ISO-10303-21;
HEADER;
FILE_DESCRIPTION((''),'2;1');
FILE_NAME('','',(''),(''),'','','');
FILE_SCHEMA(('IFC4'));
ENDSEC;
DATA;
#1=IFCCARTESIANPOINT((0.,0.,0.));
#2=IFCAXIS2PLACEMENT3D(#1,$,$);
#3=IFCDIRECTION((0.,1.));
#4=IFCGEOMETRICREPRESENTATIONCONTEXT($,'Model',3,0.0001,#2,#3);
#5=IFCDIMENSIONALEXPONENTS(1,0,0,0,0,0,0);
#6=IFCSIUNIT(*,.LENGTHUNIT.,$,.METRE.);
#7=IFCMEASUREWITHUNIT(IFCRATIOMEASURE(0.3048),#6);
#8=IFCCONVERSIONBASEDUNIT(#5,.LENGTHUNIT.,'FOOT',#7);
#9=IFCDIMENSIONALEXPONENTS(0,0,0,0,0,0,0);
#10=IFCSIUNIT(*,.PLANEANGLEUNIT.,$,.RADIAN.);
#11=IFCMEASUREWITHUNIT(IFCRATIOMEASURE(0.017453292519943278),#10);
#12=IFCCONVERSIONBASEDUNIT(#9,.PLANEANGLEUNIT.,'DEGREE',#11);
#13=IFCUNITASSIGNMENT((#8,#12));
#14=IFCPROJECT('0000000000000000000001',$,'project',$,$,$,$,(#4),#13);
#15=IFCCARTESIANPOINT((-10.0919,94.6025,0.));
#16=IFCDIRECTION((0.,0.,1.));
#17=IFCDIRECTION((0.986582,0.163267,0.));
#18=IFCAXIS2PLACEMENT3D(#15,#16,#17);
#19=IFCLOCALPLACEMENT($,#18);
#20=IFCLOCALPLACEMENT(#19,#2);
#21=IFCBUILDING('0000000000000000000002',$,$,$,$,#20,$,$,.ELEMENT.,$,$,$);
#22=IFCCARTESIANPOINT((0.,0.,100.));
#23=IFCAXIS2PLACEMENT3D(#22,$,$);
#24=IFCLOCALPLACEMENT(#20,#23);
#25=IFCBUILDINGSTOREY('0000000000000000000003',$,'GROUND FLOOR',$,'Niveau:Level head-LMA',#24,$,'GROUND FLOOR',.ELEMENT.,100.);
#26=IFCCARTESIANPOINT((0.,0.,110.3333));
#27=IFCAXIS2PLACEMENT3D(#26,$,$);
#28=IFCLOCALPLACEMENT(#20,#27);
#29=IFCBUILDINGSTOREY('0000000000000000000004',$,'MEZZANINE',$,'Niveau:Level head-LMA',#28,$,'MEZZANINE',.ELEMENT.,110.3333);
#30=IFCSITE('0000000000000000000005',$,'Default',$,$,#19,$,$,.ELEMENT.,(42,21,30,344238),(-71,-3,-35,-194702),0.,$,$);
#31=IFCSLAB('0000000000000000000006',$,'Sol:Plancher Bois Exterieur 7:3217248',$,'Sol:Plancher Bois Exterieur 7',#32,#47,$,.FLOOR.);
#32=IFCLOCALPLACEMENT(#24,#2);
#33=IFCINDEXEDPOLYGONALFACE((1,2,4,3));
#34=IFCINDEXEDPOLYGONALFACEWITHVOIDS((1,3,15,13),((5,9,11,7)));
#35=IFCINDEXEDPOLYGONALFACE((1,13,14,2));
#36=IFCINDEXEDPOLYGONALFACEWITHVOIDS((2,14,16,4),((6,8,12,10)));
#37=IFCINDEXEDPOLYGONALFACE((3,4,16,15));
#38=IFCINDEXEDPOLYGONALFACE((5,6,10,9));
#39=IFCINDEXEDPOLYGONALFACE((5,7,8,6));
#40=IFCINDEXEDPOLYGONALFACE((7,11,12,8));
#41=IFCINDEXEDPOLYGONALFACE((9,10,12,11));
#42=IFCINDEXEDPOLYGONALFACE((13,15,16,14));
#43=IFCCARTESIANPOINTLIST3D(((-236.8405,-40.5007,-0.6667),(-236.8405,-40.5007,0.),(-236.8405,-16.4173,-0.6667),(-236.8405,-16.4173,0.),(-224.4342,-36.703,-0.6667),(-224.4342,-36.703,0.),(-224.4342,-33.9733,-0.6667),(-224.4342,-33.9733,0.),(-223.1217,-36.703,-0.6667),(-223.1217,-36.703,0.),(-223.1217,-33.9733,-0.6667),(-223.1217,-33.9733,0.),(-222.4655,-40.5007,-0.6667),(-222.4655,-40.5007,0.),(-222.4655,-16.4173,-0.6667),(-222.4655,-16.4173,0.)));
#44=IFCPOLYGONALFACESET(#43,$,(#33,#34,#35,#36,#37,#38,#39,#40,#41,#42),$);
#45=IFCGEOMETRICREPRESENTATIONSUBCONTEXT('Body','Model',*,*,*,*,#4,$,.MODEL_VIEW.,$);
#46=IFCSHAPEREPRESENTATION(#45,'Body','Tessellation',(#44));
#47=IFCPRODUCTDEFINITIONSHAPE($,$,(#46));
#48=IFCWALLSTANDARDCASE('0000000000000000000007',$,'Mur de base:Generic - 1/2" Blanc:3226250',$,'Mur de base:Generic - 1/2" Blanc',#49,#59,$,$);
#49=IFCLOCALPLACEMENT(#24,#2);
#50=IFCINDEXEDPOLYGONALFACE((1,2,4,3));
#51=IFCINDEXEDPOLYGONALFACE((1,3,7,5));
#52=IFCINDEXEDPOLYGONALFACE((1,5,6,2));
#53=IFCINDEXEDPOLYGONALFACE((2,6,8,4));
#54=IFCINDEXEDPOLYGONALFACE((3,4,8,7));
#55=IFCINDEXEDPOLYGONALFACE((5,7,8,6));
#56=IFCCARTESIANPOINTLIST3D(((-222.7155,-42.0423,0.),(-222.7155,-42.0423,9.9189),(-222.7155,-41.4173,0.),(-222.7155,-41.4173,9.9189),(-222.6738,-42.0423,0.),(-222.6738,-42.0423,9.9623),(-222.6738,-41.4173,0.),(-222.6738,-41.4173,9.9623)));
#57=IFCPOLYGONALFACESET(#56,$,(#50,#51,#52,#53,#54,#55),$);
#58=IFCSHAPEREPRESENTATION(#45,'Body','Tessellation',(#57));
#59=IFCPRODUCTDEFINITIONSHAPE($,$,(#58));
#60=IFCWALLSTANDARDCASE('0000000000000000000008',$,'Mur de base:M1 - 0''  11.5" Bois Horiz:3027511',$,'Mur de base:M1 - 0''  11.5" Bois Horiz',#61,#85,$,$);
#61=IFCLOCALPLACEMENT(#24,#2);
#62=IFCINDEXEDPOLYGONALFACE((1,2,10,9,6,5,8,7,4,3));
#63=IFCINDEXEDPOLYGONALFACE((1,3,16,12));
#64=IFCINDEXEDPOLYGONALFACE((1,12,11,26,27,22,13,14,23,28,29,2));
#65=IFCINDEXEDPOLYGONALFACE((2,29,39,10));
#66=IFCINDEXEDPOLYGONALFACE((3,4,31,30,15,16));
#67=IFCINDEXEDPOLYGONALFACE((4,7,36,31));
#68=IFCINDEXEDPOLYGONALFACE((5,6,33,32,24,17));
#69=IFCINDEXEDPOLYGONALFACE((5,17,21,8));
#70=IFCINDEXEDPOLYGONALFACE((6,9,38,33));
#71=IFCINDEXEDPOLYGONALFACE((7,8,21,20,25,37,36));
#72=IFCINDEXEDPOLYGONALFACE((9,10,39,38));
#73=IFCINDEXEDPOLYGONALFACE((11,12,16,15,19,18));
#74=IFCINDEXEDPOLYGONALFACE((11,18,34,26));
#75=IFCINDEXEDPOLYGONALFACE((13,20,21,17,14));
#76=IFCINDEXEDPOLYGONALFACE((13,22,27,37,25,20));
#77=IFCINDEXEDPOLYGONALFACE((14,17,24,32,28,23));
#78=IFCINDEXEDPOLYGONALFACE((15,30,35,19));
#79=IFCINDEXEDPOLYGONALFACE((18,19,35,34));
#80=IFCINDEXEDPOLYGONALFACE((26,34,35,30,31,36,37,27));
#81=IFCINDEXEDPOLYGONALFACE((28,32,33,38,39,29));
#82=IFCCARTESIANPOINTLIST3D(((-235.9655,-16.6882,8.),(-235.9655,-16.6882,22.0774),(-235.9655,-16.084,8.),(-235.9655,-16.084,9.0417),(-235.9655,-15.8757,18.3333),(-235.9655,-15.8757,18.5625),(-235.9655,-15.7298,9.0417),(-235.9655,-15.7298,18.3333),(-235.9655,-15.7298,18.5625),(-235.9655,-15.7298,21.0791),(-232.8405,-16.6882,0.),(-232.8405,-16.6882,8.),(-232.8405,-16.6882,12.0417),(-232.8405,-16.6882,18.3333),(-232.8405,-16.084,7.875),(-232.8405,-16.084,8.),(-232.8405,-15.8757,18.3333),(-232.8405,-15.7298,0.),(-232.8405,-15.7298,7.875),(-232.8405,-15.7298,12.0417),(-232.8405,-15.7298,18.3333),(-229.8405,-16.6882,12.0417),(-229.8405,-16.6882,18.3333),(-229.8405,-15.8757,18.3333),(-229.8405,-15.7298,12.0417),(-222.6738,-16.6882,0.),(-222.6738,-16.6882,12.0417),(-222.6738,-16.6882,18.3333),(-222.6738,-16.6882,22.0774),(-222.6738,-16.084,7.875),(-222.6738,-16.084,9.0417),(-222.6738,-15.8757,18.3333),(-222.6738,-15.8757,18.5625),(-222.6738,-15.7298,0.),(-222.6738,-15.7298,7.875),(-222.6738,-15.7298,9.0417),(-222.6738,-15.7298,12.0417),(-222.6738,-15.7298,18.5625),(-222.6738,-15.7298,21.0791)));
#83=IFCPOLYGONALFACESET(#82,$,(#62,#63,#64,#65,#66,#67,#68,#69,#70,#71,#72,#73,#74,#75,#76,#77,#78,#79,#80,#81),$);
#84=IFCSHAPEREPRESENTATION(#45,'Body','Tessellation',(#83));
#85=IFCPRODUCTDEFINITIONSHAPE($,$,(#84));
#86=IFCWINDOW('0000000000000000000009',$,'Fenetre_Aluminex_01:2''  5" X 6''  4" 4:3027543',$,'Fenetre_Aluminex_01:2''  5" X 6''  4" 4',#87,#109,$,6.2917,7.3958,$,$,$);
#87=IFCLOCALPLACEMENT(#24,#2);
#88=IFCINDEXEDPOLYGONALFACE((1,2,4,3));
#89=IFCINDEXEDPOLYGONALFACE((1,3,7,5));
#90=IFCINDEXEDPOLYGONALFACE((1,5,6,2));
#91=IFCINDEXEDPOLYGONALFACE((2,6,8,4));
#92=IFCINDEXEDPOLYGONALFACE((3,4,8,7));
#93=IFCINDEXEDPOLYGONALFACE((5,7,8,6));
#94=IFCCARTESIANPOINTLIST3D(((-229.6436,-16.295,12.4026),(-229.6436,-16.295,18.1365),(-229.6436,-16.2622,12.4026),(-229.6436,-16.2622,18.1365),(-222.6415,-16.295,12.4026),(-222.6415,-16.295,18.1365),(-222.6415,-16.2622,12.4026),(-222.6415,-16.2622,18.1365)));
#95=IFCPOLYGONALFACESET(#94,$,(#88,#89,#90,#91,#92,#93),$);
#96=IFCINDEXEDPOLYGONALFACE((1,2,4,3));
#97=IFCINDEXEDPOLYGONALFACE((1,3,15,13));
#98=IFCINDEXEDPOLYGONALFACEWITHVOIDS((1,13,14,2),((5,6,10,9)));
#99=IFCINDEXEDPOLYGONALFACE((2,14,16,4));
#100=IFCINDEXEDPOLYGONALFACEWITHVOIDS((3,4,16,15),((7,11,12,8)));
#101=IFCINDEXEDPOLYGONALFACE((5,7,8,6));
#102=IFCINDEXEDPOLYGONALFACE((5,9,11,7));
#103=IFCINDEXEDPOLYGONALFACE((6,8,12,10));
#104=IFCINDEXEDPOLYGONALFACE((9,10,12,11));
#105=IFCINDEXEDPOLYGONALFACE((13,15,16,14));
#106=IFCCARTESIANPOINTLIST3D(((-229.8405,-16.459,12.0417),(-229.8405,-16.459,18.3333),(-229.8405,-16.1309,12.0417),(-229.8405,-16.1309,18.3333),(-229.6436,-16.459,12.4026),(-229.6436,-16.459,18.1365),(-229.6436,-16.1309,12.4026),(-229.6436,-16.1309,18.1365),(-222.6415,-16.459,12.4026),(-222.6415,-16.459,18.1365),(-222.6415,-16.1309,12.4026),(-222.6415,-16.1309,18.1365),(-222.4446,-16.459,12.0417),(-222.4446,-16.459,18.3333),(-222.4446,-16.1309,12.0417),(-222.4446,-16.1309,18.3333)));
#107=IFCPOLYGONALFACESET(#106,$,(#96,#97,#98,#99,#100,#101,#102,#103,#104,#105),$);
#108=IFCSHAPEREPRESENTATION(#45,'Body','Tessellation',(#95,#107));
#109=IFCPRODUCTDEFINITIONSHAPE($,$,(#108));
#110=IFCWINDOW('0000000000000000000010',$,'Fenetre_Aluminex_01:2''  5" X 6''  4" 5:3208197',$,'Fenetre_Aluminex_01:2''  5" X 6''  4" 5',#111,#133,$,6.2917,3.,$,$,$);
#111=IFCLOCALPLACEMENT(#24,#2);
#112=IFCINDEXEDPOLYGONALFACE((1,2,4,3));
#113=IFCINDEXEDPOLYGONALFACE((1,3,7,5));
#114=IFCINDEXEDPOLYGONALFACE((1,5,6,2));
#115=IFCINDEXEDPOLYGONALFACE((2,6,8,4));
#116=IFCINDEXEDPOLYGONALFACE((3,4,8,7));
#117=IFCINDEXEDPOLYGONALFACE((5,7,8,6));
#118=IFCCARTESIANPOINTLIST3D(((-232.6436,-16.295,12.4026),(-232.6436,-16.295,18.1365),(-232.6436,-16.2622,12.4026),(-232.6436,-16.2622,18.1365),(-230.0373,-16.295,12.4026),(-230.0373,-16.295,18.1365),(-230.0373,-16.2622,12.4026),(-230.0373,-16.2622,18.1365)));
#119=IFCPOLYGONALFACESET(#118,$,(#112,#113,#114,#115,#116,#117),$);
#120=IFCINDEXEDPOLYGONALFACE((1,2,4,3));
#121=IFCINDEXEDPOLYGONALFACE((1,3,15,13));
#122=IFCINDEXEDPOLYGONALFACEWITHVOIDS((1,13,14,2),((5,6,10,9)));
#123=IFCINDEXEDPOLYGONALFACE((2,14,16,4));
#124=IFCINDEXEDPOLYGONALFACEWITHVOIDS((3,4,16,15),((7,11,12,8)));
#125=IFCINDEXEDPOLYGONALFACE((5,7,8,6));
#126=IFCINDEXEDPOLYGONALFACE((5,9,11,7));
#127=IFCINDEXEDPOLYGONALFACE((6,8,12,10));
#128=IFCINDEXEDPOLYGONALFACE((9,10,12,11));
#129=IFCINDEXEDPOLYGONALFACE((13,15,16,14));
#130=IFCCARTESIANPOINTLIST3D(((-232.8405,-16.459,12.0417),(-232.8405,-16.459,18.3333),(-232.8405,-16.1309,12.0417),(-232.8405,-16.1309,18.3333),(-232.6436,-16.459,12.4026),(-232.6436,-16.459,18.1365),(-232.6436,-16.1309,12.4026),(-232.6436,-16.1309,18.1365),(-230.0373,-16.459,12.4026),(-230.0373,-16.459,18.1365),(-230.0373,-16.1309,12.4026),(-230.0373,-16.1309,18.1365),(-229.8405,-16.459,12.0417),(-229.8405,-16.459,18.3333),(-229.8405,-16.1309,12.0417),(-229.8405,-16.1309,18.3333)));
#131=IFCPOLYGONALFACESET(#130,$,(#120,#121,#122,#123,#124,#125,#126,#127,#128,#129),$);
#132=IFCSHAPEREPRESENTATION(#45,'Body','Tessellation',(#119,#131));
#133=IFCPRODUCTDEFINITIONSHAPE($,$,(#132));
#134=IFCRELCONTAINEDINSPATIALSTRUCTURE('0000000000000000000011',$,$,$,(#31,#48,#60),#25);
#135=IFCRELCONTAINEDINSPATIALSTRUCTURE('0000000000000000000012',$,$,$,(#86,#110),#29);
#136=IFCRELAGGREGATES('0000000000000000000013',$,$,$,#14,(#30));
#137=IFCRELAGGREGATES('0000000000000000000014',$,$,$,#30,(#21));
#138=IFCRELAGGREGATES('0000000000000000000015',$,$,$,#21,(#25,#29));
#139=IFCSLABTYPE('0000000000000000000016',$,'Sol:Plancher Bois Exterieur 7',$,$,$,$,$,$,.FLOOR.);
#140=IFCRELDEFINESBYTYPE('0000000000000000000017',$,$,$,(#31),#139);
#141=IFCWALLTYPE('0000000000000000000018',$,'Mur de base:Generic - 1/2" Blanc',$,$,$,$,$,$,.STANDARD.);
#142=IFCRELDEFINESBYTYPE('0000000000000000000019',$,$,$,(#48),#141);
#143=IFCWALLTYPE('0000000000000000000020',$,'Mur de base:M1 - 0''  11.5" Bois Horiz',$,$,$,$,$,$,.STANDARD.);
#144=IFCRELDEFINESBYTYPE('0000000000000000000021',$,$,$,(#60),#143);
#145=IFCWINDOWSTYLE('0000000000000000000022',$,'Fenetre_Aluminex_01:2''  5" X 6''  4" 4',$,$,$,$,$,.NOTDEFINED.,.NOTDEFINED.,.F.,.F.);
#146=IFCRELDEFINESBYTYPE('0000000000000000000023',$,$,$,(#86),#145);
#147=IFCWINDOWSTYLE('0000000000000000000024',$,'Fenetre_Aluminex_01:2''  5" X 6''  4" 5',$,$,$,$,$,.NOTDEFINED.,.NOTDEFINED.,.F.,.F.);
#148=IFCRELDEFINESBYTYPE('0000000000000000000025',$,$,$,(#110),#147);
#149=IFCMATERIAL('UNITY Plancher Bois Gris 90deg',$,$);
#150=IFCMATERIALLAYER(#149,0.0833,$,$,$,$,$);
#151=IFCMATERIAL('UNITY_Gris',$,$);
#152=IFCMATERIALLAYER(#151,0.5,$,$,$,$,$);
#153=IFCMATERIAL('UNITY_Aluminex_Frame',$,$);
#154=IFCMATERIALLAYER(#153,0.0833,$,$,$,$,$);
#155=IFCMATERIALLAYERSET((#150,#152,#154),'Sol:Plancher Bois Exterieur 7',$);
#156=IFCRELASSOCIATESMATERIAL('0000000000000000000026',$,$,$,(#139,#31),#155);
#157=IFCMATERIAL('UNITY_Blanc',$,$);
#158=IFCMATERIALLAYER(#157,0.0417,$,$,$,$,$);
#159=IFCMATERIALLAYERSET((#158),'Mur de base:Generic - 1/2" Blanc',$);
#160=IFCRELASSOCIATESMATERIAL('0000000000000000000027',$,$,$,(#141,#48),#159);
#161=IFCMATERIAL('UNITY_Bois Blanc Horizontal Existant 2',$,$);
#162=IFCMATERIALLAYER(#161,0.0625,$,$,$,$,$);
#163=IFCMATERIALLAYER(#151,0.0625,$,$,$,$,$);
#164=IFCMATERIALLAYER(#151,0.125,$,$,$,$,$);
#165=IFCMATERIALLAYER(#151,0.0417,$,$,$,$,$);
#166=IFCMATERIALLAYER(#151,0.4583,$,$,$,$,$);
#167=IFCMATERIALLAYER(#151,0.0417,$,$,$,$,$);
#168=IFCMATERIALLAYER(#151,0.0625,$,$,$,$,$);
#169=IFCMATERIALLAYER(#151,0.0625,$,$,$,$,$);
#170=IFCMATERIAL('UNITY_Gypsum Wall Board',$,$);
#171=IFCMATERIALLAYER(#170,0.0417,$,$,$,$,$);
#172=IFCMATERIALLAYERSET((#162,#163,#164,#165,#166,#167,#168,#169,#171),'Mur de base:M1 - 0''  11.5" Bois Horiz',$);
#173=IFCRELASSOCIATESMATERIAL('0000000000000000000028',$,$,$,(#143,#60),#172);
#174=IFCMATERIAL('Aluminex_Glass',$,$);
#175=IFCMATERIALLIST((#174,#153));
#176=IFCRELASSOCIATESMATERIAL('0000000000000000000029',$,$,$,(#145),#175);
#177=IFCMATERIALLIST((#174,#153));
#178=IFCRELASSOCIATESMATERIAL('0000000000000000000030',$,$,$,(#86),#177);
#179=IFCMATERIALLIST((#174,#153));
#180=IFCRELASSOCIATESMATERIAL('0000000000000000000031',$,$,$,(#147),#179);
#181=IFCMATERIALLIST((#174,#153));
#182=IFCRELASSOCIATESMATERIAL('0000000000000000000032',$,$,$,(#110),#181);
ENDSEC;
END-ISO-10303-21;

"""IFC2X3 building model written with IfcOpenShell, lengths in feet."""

from ifc_helpers import new_model, entity, si_unit, converted_unit, direction, frame, frame_2d, origin, origin_2d_with_axis, place, context, subcontext, project, spatial, polyline, rectangle, outline, extrude, clip, bounded_halfspace, source, transform, mapped, material, material_list, layer, layer_set, layer_usage, type_object, type_shapes, element, fill, save


model = new_model("IFC2X3")

# Units and contexts
model_context = context("Model", 3, precision=0.0001, world=origin(), true_north=direction((0.0, 1.0)))
body_context = subcontext(model_context, "Body", "Model", "MODEL_VIEW")
ifc_project = project(units=[converted_unit("LENGTHUNIT", "FOOT", entity("IfcRatioMeasure", 0.3048), si_unit("LENGTHUNIT", "METRE"), dimensions=[1, 0, 0, 0, 0, 0, 0]), converted_unit("PLANEANGLEUNIT", "DEGREE", entity("IfcRatioMeasure", 0.017453292519943278), si_unit("PLANEANGLEUNIT", "RADIAN"), dimensions=[0, 0, 0, 0, 0, 0, 0])], contexts=[model_context])

# Site, building, storey
site_placement = place(None, frame((-10.0919, 94.6025, 0.0), z_axis=(0.0, 0.0, 1.0), x_axis=(0.986582, 0.163267, 0.0)))
site = spatial("IfcSite", under=ifc_project, at=site_placement, Name="Default", CompositionType="ELEMENT", RefLatitude=(42, 21, 30, 344238), RefLongitude=(-71, -3, -35, -194702), RefElevation=0.0)
building_placement = place(site_placement, origin())
building = spatial("IfcBuilding", under=site, at=building_placement, CompositionType="ELEMENT")
storey_1_placement = place(building_placement, frame((0.0, 0.0, 100.0)))
storey_1 = spatial("IfcBuildingStorey", under=building, at=storey_1_placement, Name="GROUND FLOOR", ObjectType="Niveau:Level head-LMA", LongName="GROUND FLOOR", CompositionType="ELEMENT", Elevation=100.0)

# Shared definitions
ifc_material_1 = material(Name="UNITY_Aluminex_Frame")

# Slab, opening
ifc_material_2 = material(Name="UNITY Plancher Bois Gris 90deg")
ifc_layer_1 = layer(ifc_material_2, 0.0833)
ifc_material_3 = material(Name="UNITY_Gris")
ifc_layer_2 = layer(ifc_material_3, 0.5)
ifc_layer_3 = layer(ifc_material_1, 0.0833)
ifc_layer_set_1 = layer_set([ifc_layer_1, ifc_layer_2, ifc_layer_3], Name="Sol:Plancher Bois Exterieur 7")
ifc_layer_usage_1 = layer_usage(ifc_layer_set_1, "AXIS3", "POSITIVE", 0.0)
slab_type = type_object("IfcSlabType", Name="Sol:Plancher Bois Exterieur 7", PredefinedType="FLOOR", material=ifc_layer_set_1)
slab_placement = place(storey_1_placement, frame((-236.8405, -40.5007, -0.6667)))
slab = element("IfcSlab", 1, at=slab_placement, inside=storey_1, type_object=slab_type, material=ifc_layer_usage_1, Name="Sol:Plancher Bois Exterieur 7:3217248", ObjectType="Sol:Plancher Bois Exterieur 7", PredefinedType="FLOOR", context=body_context, shape_type="SweptSolid", body=[
    extrude(rectangle(XDim=24.0833, YDim=14.375, at=frame_2d((0.0, 0.0), x_axis=(0.0, 1.0))), frame((7.1875, 12.0417, 0.6667), z_axis=(0.0, 0.0, -1.0), x_axis=(-1.0, 0.0, 0.0)), (0.0, 0.0, 1.0), 0.6667),
])
opening_1_placement = place(slab_placement, frame((13.0625, 5.1625, 0.6667)))
element("IfcOpeningElement", 2, at=opening_1_placement, cuts=slab, ObjectType="Opening", context=body_context, shape_type="SweptSolid", body=[
    extrude(rectangle(XDim=2.7297, YDim=1.3125, at=origin_2d_with_axis()), frame((0.0, 0.0, 0.0), z_axis=(0.0, 0.0, -1.0), x_axis=(0.0, 1.0, 0.0)), (0.0, 0.0, 1.0), 0.6667),
])

# Wall
ifc_material_4 = material(Name="UNITY_Blanc")
ifc_layer_4 = layer(ifc_material_4, 0.0417)
ifc_layer_set_2 = layer_set([ifc_layer_4], Name="Mur de base:Generic - 1/2\" Blanc")
ifc_layer_usage_2 = layer_usage(ifc_layer_set_2, "AXIS2", "POSITIVE", -0.0208)
wall_type_1 = type_object("IfcWallType", Name="Mur de base:Generic - 1/2\" Blanc", PredefinedType="STANDARD", material=ifc_layer_set_2)
wall_1_placement = place(storey_1_placement, frame((-222.6947, -41.4173, 0.0), z_axis=(0.0, 0.0, 1.0), x_axis=(0.0, -1.0, 0.0)))
element("IfcWallStandardCase", 3, at=wall_1_placement, inside=storey_1, type_object=wall_type_1, material=ifc_layer_usage_2, Name="Mur de base:Generic - 1/2\" Blanc:3226250", ObjectType="Mur de base:Generic - 1/2\" Blanc", context=body_context, shape_type="Clipping", body=[
    clip(extrude(rectangle(XDim=0.625, YDim=0.0417, at=frame_2d((0.3125, 0.0), x_axis=(-1.0, 0.0))), origin(), (0.0, 0.0, 1.0), 9.9623), bounded_halfspace(frame((0.0, -0.0208, 9.9189), z_axis=(0.0, -0.721387, 0.692532), x_axis=(1.0, 0.0, 0.0)), False, frame((0.0, -0.0208, 9.9189)), polyline([(0.0, 0.0), (0.625, 0.0), (0.625, 0.0417), (0.0, 0.0417), (0.0, 0.0)]))),
])

# Wall, openings
ifc_material_5 = material(Name="UNITY_Bois Blanc Horizontal Existant 2")
ifc_layer_5 = layer(ifc_material_5, 0.0625)
ifc_layer_6 = layer(ifc_material_3, 0.0625)
ifc_layer_7 = layer(ifc_material_3, 0.125)
ifc_layer_8 = layer(ifc_material_3, 0.0417)
ifc_layer_9 = layer(ifc_material_3, 0.4583)
ifc_layer_10 = layer(ifc_material_3, 0.0417)
ifc_layer_11 = layer(ifc_material_3, 0.0625)
ifc_layer_12 = layer(ifc_material_3, 0.0625)
ifc_material_6 = material(Name="UNITY_Gypsum Wall Board")
ifc_layer_13 = layer(ifc_material_6, 0.0417)
ifc_layer_set_3 = layer_set([ifc_layer_5, ifc_layer_6, ifc_layer_7, ifc_layer_8, ifc_layer_9, ifc_layer_10, ifc_layer_11, ifc_layer_12, ifc_layer_13], Name="Mur de base:M1 - 0'  11.5\" Bois Horiz")
ifc_layer_usage_3 = layer_usage(ifc_layer_set_3, "AXIS2", "NEGATIVE", 0.4792)
wall_type_2 = type_object("IfcWallType", Name="Mur de base:M1 - 0'  11.5\" Bois Horiz", PredefinedType="STANDARD", material=ifc_layer_set_3)
wall_2_placement = place(storey_1_placement, frame((-222.6738, -16.209, 0.0), z_axis=(0.0, 0.0, 1.0), x_axis=(-1.0, 0.0, 0.0)))
wall_2 = element("IfcWallStandardCase", 4, at=wall_2_placement, inside=storey_1, type_object=wall_type_2, material=ifc_layer_usage_3, Name="Mur de base:M1 - 0'  11.5\" Bois Horiz:3027511", ObjectType="Mur de base:M1 - 0'  11.5\" Bois Horiz", context=body_context, shape_type="Clipping", body=[
    clip(clip(clip(extrude(rectangle(XDim=13.2917, YDim=0.9583, at=frame_2d((6.6458, 0.0), x_axis=(-1.0, 0.0))), origin(), (0.0, 0.0, 1.0), 22.0774), bounded_halfspace(frame((0.0, -0.4792, 21.0791), z_axis=(0.0, -0.721387, 0.692532), x_axis=(1.0, 0.0, 0.0)), False, frame((0.0, -0.4792, 21.0791)), polyline([(0.0, 0.0), (13.2917, 0.0), (13.2917, 0.2708), (13.2917, 0.9583), (0.0, 0.9583), (0.0, 0.0)]))), bounded_halfspace(frame((13.2917, -0.125, 9.0417), z_axis=(0.0, 1.0, 0.0), x_axis=(0.0, 0.0, 1.0)), True, frame((13.2917, -0.125, 9.0417), z_axis=(0.0, 1.0, 0.0), x_axis=(0.0, 0.0, 1.0)), polyline([(0.0, 0.0), (-1.0417, 0.0), (-1.0417, -3.125), (-1.1667, -3.125), (-1.1667, -13.2917), (0.0, -13.2917), (0.0, 0.0)]))), bounded_halfspace(frame((10.1666, -0.3333, 18.3333), z_axis=(0.0, 1.0, 0.0), x_axis=(0.0, 0.0, -1.0)), True, frame((10.1666, -0.3333, 18.3333), z_axis=(0.0, 1.0, 0.0), x_axis=(0.0, 0.0, -1.0)), polyline([(0.0, 0.0), (0.0, 10.1666), (-0.2292, 10.1666), (-0.2292, -3.125), (0.0, -3.125), (0.0, 0.0)]))),
])
opening_2_placement = place(wall_2_placement, origin())
element("IfcOpeningElement", 5, at=opening_2_placement, cuts=wall_2, ObjectType="Opening", context=body_context, shape_type="SweptSolid", body=[
    extrude(rectangle(XDim=6.2917, YDim=0.6875, at=frame_2d((0.0, 0.0), x_axis=(0.0, 1.0))), frame((-0.3438, 0.25, 15.1875), z_axis=(0.0, 1.0, 0.0), x_axis=(1.0, 0.0, 0.0)), (0.0, 0.0, 1.0), 3.0),
])
opening_3_placement = place(wall_2_placement, origin())
element("IfcOpeningElement", 6, at=opening_3_placement, cuts=wall_2, ObjectType="Opening", context=body_context, shape_type="SweptSolid", body=[
    extrude(rectangle(XDim=8.0, YDim=0.6667, at=frame_2d((0.0, 0.0), x_axis=(0.0, 1.0))), frame((13.6666, -3.0, 4.0), z_axis=(0.0, 1.0, 0.0), x_axis=(-1.0, 0.0, 0.0)), (0.0, 0.0, 1.0), 2.875),
])
opening_4_placement = place(wall_2_placement, frame((-222.6738, -16.209, 0.0), z_axis=(0.0, 0.0, 1.0), x_axis=(-1.0, 0.0, 0.0)))
element("IfcOpeningElement", 7, at=opening_4_placement, cuts=wall_2, ObjectType="Opening", context=body_context, shape_type="SweptSolid", body=[
    extrude(rectangle(XDim=8.0, YDim=3.1667, at=frame_2d((0.0, 0.0), x_axis=(0.0, 1.0))), frame((-234.4238, -11.6882, 4.0), z_axis=(0.0, -1.0, 0.0), x_axis=(1.0, 0.0, 0.0)), (0.0, 0.0, 1.0), 10.0),
])
opening_5_placement = place(wall_2_placement, frame((-0.2292, -0.4792, 12.0417)))
opening_5 = element("IfcOpeningElement", 8, at=opening_5_placement, cuts=wall_2, ObjectType="Opening", context=body_context, shape_type="SweptSolid", body=[
    extrude(rectangle(XDim=6.2917, YDim=7.3958, at=frame_2d((3.1458, 3.6979), x_axis=(1.0, 0.0))), frame((0.0, 0.0, 0.0), z_axis=(0.0, 1.0, 0.0), x_axis=(0.0, 0.0, 1.0)), (0.0, 0.0, 1.0), 0.9583),
])
opening_6_placement = place(wall_2_placement, frame((7.1666, -0.4792, 12.0417)))
opening_6 = element("IfcOpeningElement", 9, at=opening_6_placement, cuts=wall_2, ObjectType="Opening", context=body_context, shape_type="SweptSolid", body=[
    extrude(rectangle(XDim=6.2917, YDim=3.0, at=frame_2d((3.1458, 1.5), x_axis=(1.0, 0.0))), frame((0.0, 0.0, 0.0), z_axis=(0.0, 1.0, 0.0), x_axis=(0.0, 0.0, 1.0)), (0.0, 0.0, 1.0), 0.9583),
])

# Shared definitions
storey_2_placement = place(building_placement, frame((0.0, 0.0, 110.3333)))
storey_2 = spatial("IfcBuildingStorey", under=building, at=storey_2_placement, Name="MEZZANINE", ObjectType="Niveau:Level head-LMA", LongName="MEZZANINE", CompositionType="ELEMENT", Elevation=110.3333)

# Windows
ifc_material_7 = material(Name="Aluminex_Glass")
ifc_material_list_1 = material_list([ifc_material_7, ifc_material_1])
ifc_material_list_2 = material_list([ifc_material_7, ifc_material_1])
window_style_1 = type_object("IfcWindowStyle", Name="Fenetre_Aluminex_01:2'  5\" X 6'  4\" 4", ConstructionType="NOTDEFINED", OperationType="NOTDEFINED", ParameterTakesPrecedence=False, Sizeable=False, material=ifc_material_list_2)
shared_shape_1 = source(origin(), body_context, "Body", "SweptSolid", [
    extrude(rectangle(XDim=0.0328, YDim=7.0021, at=frame_2d((0.0, 0.0), x_axis=(1.0, 0.0))), frame((3.6979, 0.5487, 0.3609), z_axis=(0.0, 0.0, 1.0), x_axis=(0.0, 1.0, 0.0)), (0.0, 0.0, 1.0), 5.7339),
    extrude(outline(polyline([(-3.6979, -3.1458), (3.6979, -3.1458), (3.6979, 3.1458), (-3.6979, 3.1458), (-3.6979, -3.1458)]), holes=[polyline([(-3.5011, -2.949), (-3.5011, 2.7849), (3.5011, 2.7849), (3.5011, -2.949), (-3.5011, -2.949)])]), frame((3.6979, 0.4011, 3.1458), z_axis=(0.0, 1.0, 0.0), x_axis=(1.0, 0.0, 0.0)), (0.0, 0.0, 1.0), 0.3281),
])
type_shapes(window_style_1, [shared_shape_1])
window_1_placement = place(opening_5_placement, origin())
window_1 = element("IfcWindow", 10, at=window_1_placement, inside=storey_2, type_object=window_style_1, material=ifc_material_list_1, Name="Fenetre_Aluminex_01:2'  5\" X 6'  4\" 4:3027543", ObjectType="Fenetre_Aluminex_01:2'  5\" X 6'  4\" 4", OverallHeight=6.2917, OverallWidth=7.3958, context=body_context, shape_type="MappedRepresentation", body=[
    mapped(shared_shape_1, transform((0.0, 0.0, 0.0), scale=1.0)),
])
fill(opening_5, window_1)
ifc_material_list_3 = material_list([ifc_material_7, ifc_material_1])
ifc_material_list_4 = material_list([ifc_material_7, ifc_material_1])
window_style_2 = type_object("IfcWindowStyle", Name="Fenetre_Aluminex_01:2'  5\" X 6'  4\" 5", ConstructionType="NOTDEFINED", OperationType="NOTDEFINED", ParameterTakesPrecedence=False, Sizeable=False, material=ifc_material_list_4)
shared_shape_2 = source(origin(), body_context, "Body", "SweptSolid", [
    extrude(rectangle(XDim=0.0328, YDim=2.6063, at=frame_2d((0.0, 0.0), x_axis=(1.0, 0.0))), frame((1.5, 0.5487, 0.3609), z_axis=(0.0, 0.0, 1.0), x_axis=(0.0, 1.0, 0.0)), (0.0, 0.0, 1.0), 5.7339),
    extrude(outline(polyline([(-1.5, -3.1458), (1.5, -3.1458), (1.5, 3.1458), (-1.5, 3.1458), (-1.5, -3.1458)]), holes=[polyline([(-1.3031, -2.949), (-1.3031, 2.7849), (1.3031, 2.7849), (1.3031, -2.949), (-1.3031, -2.949)])]), frame((1.5, 0.4011, 3.1458), z_axis=(0.0, 1.0, 0.0), x_axis=(1.0, 0.0, 0.0)), (0.0, 0.0, 1.0), 0.3281),
])
type_shapes(window_style_2, [shared_shape_2])
window_2_placement = place(opening_6_placement, origin())
window_2 = element("IfcWindow", 11, at=window_2_placement, inside=storey_2, type_object=window_style_2, material=ifc_material_list_3, Name="Fenetre_Aluminex_01:2'  5\" X 6'  4\" 5:3208197", ObjectType="Fenetre_Aluminex_01:2'  5\" X 6'  4\" 5", OverallHeight=6.2917, OverallWidth=3.0, context=body_context, shape_type="MappedRepresentation", body=[
    mapped(shared_shape_2, transform((0.0, 0.0, 0.0), scale=1.0)),
])
fill(opening_6, window_2)

save(model, "model.ifc")
